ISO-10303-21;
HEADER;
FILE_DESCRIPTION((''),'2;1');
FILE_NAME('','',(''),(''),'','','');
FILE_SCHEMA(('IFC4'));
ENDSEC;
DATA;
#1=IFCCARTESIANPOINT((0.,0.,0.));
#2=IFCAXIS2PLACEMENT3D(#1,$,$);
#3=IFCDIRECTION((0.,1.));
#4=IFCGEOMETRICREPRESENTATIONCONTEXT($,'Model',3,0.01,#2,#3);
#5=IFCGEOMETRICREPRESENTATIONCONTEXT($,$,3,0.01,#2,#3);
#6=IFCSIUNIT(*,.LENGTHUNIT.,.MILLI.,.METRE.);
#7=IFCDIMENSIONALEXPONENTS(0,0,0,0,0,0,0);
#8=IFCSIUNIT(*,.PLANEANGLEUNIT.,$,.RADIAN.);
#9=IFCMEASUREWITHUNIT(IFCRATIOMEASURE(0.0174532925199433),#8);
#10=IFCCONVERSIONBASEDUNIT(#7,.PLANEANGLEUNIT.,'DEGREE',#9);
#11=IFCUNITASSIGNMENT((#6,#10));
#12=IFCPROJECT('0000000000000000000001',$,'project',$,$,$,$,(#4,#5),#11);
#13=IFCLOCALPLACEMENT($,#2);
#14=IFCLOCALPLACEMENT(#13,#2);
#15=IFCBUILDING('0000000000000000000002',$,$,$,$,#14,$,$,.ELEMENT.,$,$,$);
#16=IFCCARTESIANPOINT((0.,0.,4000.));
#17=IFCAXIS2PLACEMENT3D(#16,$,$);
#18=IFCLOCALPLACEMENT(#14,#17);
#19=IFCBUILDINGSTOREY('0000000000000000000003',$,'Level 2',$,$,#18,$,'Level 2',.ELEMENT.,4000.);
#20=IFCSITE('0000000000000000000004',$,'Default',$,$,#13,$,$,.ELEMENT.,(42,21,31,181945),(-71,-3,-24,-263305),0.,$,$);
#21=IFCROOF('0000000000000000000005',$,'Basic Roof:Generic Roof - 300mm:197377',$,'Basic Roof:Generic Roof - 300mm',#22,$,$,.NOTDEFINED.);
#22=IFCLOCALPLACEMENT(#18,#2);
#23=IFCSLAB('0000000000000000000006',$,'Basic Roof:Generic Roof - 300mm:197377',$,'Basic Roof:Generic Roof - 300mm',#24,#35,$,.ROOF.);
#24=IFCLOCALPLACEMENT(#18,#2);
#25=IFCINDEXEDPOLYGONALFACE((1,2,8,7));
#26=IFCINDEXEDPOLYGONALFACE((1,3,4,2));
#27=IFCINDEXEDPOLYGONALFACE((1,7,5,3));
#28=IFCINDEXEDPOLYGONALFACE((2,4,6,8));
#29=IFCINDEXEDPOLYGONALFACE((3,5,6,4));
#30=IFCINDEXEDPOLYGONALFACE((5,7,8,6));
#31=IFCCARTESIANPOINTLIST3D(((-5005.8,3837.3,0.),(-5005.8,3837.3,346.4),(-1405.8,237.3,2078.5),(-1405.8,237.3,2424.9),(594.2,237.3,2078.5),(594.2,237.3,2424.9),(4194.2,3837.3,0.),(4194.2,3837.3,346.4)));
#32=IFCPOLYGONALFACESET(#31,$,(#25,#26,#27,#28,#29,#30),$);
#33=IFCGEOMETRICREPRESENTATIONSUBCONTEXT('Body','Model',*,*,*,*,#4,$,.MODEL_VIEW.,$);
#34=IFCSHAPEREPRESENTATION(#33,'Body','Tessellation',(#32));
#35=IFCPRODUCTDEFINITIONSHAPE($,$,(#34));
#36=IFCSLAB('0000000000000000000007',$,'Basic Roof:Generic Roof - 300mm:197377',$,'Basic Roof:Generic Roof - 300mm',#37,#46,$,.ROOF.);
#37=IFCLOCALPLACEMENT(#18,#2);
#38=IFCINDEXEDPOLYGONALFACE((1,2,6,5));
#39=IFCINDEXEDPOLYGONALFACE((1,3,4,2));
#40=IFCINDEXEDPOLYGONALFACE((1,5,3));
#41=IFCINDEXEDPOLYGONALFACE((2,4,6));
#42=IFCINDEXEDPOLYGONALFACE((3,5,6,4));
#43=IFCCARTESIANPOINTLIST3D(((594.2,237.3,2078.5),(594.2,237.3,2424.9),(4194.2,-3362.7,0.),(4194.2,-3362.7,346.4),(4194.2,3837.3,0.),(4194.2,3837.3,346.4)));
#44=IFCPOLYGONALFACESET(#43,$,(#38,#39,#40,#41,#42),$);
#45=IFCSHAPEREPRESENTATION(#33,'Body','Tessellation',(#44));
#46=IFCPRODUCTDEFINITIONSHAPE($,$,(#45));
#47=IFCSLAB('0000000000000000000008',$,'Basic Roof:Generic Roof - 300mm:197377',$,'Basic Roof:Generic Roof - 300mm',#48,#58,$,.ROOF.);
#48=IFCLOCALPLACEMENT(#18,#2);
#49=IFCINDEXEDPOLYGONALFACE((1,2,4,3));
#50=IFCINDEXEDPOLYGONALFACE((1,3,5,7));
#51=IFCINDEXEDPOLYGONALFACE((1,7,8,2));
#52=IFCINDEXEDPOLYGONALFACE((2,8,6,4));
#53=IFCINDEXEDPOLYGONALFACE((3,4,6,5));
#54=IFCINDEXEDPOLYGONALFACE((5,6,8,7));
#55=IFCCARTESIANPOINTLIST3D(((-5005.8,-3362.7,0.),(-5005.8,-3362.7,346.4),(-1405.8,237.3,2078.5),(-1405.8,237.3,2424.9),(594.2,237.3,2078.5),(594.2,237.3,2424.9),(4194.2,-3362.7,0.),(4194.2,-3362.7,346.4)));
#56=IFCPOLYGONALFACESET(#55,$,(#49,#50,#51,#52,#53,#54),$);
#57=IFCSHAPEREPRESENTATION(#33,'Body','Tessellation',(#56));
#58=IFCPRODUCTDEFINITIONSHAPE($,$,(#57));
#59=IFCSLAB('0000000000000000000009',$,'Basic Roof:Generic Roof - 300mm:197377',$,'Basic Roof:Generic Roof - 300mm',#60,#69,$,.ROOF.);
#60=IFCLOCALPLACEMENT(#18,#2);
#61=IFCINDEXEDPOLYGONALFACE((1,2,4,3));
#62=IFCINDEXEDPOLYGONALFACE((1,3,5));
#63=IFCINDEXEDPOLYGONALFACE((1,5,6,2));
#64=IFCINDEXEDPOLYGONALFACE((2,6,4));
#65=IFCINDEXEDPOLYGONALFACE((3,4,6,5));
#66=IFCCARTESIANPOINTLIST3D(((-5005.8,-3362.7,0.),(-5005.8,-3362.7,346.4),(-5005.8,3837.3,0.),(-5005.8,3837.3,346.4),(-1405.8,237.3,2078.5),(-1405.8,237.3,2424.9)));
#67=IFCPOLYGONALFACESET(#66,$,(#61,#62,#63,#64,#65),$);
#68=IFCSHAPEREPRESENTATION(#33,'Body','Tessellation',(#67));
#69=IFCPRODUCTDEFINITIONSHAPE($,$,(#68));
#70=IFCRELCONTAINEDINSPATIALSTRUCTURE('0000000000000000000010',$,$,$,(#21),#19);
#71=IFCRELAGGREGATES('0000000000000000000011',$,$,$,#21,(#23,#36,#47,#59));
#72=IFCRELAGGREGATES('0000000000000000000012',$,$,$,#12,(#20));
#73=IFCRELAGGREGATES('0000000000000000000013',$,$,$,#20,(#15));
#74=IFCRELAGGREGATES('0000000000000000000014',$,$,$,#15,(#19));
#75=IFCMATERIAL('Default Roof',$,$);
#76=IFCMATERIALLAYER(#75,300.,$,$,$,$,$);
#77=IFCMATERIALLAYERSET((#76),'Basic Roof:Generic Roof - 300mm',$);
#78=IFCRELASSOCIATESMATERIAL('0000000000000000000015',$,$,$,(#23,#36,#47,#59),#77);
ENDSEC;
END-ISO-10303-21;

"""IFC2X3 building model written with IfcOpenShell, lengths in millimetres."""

from ifc_helpers import new_model, entity, si_unit, converted_unit, direction, frame, origin, place, context, subcontext, project, spatial, polyline, outline, extrude, material, layer, layer_set, element, aggregate, save


model = new_model("IFC2X3")

# Units and contexts
model_context = context("Model", 3, precision=0.01, world=origin(), true_north=direction((0.0, 1.0)))
context_of_model = context(None, 3, precision=0.01, world=origin(), true_north=direction((0.0, 1.0)))
body_context = subcontext(model_context, "Body", "Model", "MODEL_VIEW")
ifc_project = project(units=[si_unit("LENGTHUNIT", "METRE", prefix="MILLI"), converted_unit("PLANEANGLEUNIT", "DEGREE", entity("IfcRatioMeasure", 0.0174532925199433), si_unit("PLANEANGLEUNIT", "RADIAN"), dimensions=[0, 0, 0, 0, 0, 0, 0])], contexts=[model_context, context_of_model])

# Site, building, storey
site_placement = place(None, origin())
site = spatial("IfcSite", under=ifc_project, at=site_placement, Name="Default", CompositionType="ELEMENT", RefLatitude=(42, 21, 31, 181945), RefLongitude=(-71, -3, -24, -263305), RefElevation=0.0)
building_placement = place(site_placement, origin())
building = spatial("IfcBuilding", under=site, at=building_placement, CompositionType="ELEMENT")
storey_placement = place(building_placement, frame((0.0, 0.0, 4000.0)))
storey = spatial("IfcBuildingStorey", under=building, at=storey_placement, Name="Level 2", LongName="Level 2", CompositionType="ELEMENT", Elevation=4000.0)

# Roof, slabs
roof_placement = place(storey_placement, frame((-5005.8, -3362.7, 0.0)))
roof = element("IfcRoof", 1, at=roof_placement, inside=storey, Name="Basic Roof:Generic Roof - 300mm:197377", ObjectType="Basic Roof:Generic Roof - 300mm", ShapeType="NOTDEFINED")
ifc_material = material(Name="Default Roof")
ifc_layer = layer(ifc_material, 300.0)
ifc_layer_set = layer_set([ifc_layer], Name="Basic Roof:Generic Roof - 300mm")
slab_1_placement = place(roof_placement, origin())
slab_1 = element("IfcSlab", 2, at=slab_1_placement, material=ifc_layer_set, Name="Basic Roof:Generic Roof - 300mm:197377", ObjectType="Basic Roof:Generic Roof - 300mm", PredefinedType="ROOF", context=body_context, shape_type="SweptSolid", body=[
    extrude(outline(polyline([(-1000.0, -2078.5), (1000.0, -2078.5), (4600.0, 2078.5), (-4600.0, 2078.5), (-1000.0, -2078.5)])), frame((4600.0, 5400.0, 1039.2), z_axis=(0.0, 0.5, 0.866025), x_axis=(1.0, 0.0, 0.0)), (0.0, -0.5, 0.866025), 346.4),
])
slab_2_placement = place(roof_placement, origin())
slab_2 = element("IfcSlab", 3, at=slab_2_placement, material=ifc_layer_set, Name="Basic Roof:Generic Roof - 300mm:197377", ObjectType="Basic Roof:Generic Roof - 300mm", PredefinedType="ROOF", context=body_context, shape_type="SweptSolid", body=[
    extrude(outline(polyline([(2078.5, -3600.0), (2078.5, 3600.0), (-2078.5, 0.0), (2078.5, -3600.0)])), frame((7400.0, 3600.0, 1039.2), z_axis=(0.5, 0.0, 0.866025), x_axis=(0.866025, 0.0, -0.5)), (-0.5, 0.0, 0.866025), 346.4),
])
slab_3_placement = place(roof_placement, origin())
slab_3 = element("IfcSlab", 4, at=slab_3_placement, material=ifc_layer_set, Name="Basic Roof:Generic Roof - 300mm:197377", ObjectType="Basic Roof:Generic Roof - 300mm", PredefinedType="ROOF", context=body_context, shape_type="SweptSolid", body=[
    extrude(outline(polyline([(-4600.0, -2078.5), (4600.0, -2078.5), (1000.0, 2078.5), (-1000.0, 2078.5), (-4600.0, -2078.5)])), frame((4600.0, 1800.0, 1039.2), z_axis=(0.0, -0.5, 0.866025), x_axis=(1.0, 0.0, 0.0)), (0.0, 0.5, 0.866025), 346.4),
])
slab_4_placement = place(roof_placement, origin())
slab_4 = element("IfcSlab", 5, at=slab_4_placement, material=ifc_layer_set, Name="Basic Roof:Generic Roof - 300mm:197377", ObjectType="Basic Roof:Generic Roof - 300mm", PredefinedType="ROOF", context=body_context, shape_type="SweptSolid", body=[
    extrude(outline(polyline([(-2078.5, 3600.0), (-2078.5, -3600.0), (2078.5, 0.0), (-2078.5, 3600.0)])), frame((1800.0, 3600.0, 1039.2), z_axis=(-0.5, 0.0, 0.866025), x_axis=(0.866025, 0.0, 0.5)), (0.5, 0.0, 0.866025), 346.4),
])
aggregate(roof, [slab_1, slab_2, slab_3, slab_4])

save(model, "model.ifc")
